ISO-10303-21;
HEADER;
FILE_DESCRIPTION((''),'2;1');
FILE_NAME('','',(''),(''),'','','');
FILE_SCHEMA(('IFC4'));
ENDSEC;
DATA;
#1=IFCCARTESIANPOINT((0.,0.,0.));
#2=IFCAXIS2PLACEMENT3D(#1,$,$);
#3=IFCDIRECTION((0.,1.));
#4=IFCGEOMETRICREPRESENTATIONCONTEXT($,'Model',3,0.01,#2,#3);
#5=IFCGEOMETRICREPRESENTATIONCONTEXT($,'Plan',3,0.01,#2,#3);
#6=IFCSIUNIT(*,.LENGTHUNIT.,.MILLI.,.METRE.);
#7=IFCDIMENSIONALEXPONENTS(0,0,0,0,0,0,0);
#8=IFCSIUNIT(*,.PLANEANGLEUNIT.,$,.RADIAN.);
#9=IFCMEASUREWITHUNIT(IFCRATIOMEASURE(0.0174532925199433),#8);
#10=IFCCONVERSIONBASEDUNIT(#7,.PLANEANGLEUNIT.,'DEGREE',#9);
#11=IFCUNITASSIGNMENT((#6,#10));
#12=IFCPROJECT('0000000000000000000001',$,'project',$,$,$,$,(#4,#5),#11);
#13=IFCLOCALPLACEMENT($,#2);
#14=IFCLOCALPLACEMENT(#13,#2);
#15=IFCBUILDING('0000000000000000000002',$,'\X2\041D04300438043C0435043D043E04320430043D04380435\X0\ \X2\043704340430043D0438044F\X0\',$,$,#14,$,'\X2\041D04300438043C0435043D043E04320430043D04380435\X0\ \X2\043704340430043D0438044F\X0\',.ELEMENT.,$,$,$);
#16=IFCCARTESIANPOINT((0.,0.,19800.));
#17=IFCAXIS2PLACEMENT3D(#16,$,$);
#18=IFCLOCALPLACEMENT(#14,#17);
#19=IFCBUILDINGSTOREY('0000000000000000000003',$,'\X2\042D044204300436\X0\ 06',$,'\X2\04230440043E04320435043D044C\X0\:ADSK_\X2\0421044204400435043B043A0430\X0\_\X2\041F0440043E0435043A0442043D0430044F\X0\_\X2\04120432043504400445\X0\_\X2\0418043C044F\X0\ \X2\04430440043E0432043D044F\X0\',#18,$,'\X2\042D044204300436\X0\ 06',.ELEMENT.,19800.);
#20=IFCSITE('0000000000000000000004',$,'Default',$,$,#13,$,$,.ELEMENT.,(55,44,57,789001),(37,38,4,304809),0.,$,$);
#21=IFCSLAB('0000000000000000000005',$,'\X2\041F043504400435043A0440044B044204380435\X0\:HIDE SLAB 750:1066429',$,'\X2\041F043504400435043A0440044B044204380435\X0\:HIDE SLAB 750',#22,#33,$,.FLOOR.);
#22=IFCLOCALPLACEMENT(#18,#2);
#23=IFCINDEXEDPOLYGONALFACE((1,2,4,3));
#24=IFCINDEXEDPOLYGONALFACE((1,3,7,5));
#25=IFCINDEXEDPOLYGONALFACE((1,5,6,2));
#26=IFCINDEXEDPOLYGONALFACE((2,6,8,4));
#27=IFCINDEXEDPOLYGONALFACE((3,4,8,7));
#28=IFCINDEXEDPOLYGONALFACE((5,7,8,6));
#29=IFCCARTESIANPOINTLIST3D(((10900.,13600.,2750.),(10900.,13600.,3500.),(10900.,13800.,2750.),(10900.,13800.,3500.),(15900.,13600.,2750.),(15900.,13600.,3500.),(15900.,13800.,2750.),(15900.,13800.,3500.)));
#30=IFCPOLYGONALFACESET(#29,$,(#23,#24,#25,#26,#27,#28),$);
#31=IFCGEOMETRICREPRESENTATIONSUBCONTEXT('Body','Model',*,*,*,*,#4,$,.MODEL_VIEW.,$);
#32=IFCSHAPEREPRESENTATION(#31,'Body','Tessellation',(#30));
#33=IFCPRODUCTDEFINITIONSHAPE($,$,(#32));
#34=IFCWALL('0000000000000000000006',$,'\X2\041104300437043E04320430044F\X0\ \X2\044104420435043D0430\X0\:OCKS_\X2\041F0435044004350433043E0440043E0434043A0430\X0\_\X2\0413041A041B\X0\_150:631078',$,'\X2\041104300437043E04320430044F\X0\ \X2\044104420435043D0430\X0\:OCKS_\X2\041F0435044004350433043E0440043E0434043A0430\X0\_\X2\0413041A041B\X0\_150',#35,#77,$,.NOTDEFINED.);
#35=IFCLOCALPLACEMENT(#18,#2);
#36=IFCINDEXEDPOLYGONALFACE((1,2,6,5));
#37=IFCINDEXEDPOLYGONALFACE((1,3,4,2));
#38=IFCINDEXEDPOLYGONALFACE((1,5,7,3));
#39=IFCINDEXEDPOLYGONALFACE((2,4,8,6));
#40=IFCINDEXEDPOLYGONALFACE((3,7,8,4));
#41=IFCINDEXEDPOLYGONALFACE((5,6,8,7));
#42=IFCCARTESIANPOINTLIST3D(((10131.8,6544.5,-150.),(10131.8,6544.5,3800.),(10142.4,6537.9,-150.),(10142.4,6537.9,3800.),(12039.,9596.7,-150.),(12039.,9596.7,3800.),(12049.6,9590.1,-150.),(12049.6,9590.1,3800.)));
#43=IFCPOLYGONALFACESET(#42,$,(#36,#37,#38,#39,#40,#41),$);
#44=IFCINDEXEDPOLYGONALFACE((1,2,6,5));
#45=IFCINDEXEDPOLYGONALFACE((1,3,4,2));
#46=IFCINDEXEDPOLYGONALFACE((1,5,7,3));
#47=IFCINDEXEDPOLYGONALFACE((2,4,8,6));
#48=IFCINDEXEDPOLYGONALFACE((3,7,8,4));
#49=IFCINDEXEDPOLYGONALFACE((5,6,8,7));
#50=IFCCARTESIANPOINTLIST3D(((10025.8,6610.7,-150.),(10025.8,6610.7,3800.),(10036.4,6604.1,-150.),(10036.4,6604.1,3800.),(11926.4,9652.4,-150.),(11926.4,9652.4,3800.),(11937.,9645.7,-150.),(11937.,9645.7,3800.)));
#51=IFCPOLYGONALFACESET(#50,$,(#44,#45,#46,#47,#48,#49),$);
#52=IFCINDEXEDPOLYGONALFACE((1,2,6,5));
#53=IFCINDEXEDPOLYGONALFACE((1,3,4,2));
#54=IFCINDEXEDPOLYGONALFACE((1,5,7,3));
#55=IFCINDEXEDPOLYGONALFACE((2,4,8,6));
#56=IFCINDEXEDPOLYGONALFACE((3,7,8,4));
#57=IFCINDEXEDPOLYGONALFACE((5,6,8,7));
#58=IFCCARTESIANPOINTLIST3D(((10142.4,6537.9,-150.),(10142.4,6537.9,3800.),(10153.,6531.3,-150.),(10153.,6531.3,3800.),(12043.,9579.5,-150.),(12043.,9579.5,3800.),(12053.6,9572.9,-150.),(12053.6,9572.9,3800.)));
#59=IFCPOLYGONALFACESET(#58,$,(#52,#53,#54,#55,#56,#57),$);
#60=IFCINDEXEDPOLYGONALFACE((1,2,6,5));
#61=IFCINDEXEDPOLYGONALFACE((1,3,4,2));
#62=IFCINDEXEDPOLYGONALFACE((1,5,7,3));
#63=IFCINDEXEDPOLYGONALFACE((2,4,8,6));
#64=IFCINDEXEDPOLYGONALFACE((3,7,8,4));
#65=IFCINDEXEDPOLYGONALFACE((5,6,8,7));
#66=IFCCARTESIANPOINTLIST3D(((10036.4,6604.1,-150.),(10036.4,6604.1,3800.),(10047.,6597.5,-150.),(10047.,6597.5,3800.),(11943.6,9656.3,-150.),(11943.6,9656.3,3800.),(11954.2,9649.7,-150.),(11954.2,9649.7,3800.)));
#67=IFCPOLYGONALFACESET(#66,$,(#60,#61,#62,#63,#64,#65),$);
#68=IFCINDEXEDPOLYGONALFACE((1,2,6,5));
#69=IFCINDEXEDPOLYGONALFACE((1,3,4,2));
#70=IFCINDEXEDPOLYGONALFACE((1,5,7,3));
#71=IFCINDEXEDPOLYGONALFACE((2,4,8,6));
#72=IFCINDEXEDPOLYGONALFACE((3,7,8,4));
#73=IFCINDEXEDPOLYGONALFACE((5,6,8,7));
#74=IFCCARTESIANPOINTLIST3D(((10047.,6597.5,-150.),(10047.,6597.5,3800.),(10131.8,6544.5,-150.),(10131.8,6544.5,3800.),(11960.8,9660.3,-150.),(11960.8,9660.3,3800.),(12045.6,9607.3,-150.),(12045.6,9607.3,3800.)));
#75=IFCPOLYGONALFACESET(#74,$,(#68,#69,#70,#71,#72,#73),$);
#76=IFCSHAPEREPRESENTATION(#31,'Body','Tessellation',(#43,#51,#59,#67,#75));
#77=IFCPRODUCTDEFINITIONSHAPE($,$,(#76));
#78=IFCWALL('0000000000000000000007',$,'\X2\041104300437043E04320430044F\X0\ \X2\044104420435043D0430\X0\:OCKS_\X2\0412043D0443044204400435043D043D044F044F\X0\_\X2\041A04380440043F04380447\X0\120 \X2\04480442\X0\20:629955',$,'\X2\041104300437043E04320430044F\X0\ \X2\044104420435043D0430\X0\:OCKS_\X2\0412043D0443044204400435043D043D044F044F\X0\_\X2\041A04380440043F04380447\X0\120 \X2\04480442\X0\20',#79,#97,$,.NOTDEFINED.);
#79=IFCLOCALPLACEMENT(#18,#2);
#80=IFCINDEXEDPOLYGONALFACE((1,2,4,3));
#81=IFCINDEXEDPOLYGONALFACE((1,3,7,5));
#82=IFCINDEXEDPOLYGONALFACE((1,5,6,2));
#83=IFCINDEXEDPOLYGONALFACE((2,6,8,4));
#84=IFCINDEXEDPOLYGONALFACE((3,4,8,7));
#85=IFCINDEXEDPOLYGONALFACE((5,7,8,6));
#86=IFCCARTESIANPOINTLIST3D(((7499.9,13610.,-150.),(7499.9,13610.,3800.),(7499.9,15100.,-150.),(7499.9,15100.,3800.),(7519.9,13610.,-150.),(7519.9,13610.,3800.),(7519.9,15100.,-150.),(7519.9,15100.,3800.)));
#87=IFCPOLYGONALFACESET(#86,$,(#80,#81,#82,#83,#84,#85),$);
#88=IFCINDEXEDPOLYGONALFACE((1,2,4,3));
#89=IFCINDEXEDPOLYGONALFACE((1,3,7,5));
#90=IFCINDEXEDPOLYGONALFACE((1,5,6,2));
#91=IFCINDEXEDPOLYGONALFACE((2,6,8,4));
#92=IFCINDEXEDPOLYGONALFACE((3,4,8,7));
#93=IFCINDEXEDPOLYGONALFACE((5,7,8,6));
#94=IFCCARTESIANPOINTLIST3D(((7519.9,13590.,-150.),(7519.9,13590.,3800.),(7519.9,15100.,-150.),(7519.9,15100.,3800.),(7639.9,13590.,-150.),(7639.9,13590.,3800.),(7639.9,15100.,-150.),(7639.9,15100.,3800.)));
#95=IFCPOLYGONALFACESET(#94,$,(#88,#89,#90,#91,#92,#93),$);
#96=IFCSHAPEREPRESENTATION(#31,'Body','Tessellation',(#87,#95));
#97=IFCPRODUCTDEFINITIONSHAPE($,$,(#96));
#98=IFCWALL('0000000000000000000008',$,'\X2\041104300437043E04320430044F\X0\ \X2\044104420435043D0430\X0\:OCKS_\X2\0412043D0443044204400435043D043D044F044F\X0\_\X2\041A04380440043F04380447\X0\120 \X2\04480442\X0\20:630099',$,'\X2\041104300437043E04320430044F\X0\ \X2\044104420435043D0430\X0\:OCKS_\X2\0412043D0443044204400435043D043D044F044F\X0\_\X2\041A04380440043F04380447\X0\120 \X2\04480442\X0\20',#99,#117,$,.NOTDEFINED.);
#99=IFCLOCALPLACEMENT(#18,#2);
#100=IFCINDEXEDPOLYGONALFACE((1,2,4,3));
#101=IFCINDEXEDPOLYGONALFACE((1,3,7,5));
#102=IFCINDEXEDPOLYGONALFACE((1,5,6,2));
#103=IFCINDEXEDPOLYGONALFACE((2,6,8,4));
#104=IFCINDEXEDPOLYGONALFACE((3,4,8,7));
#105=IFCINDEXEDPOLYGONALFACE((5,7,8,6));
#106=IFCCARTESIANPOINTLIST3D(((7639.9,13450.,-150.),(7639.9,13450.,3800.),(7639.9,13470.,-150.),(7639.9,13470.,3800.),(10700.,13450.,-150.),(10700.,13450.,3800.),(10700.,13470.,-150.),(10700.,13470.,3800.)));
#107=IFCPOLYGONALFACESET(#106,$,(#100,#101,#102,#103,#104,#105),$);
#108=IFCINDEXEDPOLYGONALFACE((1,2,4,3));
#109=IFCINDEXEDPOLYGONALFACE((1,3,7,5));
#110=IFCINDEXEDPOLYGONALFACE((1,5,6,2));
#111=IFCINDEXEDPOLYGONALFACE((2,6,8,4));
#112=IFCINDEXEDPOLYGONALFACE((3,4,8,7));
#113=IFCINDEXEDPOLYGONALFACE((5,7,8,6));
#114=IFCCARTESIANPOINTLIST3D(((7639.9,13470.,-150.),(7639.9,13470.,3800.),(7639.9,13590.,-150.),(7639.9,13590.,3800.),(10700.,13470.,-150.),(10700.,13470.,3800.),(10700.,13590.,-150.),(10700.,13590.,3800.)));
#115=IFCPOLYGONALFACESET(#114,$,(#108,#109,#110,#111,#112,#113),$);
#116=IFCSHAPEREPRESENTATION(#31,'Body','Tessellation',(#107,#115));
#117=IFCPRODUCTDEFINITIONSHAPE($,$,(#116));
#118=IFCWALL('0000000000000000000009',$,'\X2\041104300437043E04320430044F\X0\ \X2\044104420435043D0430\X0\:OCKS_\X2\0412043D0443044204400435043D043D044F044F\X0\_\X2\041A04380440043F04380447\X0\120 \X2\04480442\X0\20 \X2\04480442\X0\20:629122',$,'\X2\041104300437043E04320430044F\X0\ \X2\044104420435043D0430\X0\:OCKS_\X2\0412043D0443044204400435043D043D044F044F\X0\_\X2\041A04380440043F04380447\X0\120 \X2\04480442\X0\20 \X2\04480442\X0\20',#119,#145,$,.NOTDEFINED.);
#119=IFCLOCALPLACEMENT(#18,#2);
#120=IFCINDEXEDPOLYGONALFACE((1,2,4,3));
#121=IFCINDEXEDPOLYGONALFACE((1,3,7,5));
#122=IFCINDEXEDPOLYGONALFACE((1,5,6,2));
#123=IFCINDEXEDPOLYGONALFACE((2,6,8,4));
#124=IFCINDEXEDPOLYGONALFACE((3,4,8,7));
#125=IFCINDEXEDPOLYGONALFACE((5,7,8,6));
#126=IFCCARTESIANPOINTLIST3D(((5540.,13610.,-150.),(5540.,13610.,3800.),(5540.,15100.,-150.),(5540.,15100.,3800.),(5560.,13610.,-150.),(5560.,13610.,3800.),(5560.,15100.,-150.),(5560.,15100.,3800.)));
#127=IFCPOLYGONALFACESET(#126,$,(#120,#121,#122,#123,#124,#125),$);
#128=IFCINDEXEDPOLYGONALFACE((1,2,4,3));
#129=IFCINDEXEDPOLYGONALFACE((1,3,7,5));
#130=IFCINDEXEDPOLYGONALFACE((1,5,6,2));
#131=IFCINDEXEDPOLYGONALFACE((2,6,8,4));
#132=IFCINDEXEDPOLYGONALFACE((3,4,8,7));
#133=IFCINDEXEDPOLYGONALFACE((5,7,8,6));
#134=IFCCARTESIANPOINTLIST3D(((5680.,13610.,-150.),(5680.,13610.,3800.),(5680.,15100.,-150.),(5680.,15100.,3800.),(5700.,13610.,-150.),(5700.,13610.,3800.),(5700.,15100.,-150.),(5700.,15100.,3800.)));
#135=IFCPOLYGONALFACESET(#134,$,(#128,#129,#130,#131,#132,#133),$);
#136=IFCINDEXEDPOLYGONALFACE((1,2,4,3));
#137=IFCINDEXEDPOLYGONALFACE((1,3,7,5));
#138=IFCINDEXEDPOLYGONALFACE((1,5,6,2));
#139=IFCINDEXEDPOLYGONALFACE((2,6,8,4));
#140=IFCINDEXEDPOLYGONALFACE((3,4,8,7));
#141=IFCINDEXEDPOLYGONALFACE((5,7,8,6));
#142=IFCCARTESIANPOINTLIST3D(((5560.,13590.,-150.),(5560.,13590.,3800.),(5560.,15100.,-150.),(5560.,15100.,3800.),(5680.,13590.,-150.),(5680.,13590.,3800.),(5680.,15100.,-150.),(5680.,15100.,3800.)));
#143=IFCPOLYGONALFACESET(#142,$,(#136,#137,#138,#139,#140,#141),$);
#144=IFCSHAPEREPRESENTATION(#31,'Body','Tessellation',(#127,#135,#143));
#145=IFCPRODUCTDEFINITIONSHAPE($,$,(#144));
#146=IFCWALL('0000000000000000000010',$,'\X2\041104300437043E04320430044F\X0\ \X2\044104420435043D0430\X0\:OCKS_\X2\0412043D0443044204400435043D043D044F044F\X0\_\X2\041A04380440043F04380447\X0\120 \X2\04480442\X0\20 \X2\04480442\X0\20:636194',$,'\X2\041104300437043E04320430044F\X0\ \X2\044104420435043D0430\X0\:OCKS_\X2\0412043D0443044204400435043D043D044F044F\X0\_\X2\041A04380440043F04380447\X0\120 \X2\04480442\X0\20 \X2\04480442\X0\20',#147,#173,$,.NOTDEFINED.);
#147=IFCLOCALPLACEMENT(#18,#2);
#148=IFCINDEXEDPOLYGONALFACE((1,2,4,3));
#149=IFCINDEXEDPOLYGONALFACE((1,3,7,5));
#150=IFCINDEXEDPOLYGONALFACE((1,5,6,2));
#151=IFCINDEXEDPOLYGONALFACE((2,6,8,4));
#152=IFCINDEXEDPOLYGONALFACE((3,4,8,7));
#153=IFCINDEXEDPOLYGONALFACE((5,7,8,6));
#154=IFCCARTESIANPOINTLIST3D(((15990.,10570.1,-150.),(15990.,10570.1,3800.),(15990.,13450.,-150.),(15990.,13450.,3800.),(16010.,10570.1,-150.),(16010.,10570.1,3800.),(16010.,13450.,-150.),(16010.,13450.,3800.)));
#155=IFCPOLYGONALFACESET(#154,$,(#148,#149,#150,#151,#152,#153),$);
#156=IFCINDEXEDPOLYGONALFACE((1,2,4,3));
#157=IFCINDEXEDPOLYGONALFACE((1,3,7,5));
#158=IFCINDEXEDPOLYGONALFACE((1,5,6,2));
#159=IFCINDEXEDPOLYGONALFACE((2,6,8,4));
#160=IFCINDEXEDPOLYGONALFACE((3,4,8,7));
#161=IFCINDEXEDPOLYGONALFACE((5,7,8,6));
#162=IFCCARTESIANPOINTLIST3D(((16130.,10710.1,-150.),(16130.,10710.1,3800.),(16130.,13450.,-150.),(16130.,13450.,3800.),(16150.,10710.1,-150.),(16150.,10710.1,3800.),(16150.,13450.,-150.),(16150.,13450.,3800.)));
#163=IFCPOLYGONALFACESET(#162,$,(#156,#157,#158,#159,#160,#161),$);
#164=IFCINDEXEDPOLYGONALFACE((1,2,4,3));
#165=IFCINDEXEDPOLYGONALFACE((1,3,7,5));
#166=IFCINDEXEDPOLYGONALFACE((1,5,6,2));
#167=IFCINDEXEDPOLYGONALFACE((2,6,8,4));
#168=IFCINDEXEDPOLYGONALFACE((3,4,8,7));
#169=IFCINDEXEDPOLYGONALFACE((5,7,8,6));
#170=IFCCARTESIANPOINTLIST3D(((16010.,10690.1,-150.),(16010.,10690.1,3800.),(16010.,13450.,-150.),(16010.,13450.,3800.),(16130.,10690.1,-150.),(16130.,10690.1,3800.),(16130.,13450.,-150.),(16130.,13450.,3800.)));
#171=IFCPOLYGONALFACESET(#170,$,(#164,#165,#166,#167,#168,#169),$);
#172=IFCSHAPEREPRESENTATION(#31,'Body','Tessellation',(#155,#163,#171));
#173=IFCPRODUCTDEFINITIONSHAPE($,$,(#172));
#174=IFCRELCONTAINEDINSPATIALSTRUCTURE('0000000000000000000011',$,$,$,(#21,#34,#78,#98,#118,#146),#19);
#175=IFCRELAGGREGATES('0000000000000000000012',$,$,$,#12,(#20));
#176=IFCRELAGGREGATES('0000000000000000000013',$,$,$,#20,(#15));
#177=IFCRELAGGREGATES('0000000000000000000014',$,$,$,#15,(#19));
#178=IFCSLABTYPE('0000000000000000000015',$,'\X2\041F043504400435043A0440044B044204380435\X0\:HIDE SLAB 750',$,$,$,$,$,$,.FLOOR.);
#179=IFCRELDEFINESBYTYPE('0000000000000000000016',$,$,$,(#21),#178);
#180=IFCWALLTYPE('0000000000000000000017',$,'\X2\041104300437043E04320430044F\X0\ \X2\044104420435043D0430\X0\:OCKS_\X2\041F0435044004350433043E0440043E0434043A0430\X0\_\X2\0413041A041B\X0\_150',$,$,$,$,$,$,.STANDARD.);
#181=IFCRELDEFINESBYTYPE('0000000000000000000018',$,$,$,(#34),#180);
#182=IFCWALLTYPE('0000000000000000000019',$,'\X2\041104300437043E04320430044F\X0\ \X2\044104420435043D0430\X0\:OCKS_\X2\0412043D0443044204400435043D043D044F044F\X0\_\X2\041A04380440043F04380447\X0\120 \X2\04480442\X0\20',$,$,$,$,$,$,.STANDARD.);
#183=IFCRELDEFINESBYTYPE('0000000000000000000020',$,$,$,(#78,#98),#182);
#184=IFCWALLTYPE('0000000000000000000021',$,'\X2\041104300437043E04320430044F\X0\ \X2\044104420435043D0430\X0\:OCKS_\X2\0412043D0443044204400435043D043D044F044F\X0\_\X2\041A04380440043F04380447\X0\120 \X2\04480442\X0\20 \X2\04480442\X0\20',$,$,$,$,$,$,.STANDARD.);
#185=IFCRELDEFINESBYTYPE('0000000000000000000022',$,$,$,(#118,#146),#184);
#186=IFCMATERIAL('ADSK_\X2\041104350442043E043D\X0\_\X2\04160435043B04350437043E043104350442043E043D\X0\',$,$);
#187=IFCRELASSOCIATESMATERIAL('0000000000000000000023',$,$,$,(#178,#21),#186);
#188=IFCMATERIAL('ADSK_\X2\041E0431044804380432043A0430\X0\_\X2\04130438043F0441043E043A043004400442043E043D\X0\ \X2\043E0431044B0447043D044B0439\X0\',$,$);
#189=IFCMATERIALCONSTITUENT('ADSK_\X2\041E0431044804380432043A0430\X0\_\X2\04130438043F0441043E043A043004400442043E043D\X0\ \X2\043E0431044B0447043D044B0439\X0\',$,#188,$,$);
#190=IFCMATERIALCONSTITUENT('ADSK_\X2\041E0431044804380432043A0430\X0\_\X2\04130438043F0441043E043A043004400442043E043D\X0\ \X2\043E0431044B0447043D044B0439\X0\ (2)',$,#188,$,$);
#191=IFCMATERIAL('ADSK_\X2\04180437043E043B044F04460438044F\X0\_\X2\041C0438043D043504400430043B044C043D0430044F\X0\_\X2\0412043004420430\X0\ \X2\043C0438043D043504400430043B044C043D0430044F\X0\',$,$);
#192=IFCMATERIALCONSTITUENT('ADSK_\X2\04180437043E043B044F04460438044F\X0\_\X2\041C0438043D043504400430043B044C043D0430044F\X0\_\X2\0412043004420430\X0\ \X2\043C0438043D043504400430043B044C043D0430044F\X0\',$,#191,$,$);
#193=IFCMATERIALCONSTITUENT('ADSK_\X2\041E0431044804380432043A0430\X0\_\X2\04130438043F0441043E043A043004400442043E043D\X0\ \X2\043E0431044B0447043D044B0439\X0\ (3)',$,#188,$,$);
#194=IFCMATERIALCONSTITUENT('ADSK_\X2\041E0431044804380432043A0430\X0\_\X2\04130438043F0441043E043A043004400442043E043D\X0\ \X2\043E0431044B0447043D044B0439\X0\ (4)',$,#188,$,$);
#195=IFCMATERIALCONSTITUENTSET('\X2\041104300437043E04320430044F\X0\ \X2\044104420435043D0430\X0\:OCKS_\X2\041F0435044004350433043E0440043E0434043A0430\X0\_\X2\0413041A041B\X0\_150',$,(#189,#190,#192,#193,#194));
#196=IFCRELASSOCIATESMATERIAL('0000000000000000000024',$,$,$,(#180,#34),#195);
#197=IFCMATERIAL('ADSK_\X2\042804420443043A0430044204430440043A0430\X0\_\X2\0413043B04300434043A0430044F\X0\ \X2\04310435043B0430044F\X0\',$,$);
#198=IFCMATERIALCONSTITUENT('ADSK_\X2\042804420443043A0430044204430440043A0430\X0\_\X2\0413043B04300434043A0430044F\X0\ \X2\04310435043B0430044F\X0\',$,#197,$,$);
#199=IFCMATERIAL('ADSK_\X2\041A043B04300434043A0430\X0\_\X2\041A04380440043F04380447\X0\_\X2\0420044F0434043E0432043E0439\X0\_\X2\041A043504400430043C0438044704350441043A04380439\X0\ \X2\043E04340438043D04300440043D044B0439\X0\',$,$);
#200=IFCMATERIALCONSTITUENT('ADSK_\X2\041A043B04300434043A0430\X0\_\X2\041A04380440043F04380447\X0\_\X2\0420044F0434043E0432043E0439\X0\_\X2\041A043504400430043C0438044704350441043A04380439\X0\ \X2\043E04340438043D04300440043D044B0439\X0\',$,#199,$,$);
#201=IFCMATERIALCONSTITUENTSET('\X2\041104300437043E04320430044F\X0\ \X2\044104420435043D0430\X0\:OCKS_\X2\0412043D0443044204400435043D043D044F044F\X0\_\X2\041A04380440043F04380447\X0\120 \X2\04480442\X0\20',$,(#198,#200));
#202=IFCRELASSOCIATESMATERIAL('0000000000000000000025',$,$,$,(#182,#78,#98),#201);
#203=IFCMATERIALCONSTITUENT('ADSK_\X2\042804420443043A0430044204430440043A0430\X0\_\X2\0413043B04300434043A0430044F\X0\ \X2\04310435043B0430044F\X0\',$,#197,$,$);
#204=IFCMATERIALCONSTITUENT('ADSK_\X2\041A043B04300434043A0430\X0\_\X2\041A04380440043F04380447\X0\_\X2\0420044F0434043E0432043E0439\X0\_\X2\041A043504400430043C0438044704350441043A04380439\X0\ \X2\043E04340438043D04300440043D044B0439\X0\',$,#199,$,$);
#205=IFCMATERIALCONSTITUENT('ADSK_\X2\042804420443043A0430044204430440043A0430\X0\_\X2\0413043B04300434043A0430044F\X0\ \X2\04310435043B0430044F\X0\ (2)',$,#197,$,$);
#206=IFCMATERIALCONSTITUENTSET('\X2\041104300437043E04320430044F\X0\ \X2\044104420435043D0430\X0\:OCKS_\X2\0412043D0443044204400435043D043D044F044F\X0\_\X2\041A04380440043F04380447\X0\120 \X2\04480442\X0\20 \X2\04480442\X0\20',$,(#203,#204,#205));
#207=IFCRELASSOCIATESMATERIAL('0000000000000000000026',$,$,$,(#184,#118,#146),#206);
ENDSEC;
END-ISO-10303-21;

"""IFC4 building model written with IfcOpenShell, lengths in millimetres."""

from ifc_helpers import new_model, entity, si_unit, converted_unit, direction, frame, origin, place, context, subcontext, project, spatial, indexed_curve, outline, extrude, material, constituent, constituent_set, type_object, element, save


model = new_model("IFC4")

# Units and contexts
model_context = context("Model", 3, precision=0.01, world=origin(), true_north=direction((0.0, 1.0)))
plan_context = context("Plan", 3, precision=0.01, world=origin(), true_north=direction((0.0, 1.0)))
body_context = subcontext(model_context, "Body", "Model", "MODEL_VIEW")
ifc_project = project(units=[si_unit("LENGTHUNIT", "METRE", prefix="MILLI"), converted_unit("PLANEANGLEUNIT", "DEGREE", entity("IfcRatioMeasure", 0.0174532925199433), si_unit("PLANEANGLEUNIT", "RADIAN"), dimensions=[0, 0, 0, 0, 0, 0, 0])], contexts=[model_context, plan_context])

# Site, building, storey
site_placement = place(None, frame((0.0, 0.0, 0.0)))
site = spatial("IfcSite", under=ifc_project, at=site_placement, Name="Default", CompositionType="ELEMENT", RefLatitude=(55, 44, 57, 789001), RefLongitude=(37, 38, 4, 304809), RefElevation=0.0)
building_placement = place(site_placement, origin())
building = spatial("IfcBuilding", under=site, at=building_placement, Name="Наименование здания", LongName="Наименование здания", CompositionType="ELEMENT")
storey_placement = place(building_placement, frame((0.0, 0.0, 19800.0)))
storey = spatial("IfcBuildingStorey", under=building, at=storey_placement, Name="Этаж 06", ObjectType="Уровень:ADSK_Стрелка_Проектная_Вверх_Имя уровня", LongName="Этаж 06", CompositionType="ELEMENT", Elevation=19800.0)

# Slab
ifc_material_1 = material(Name="ADSK_Бетон_Железобетон")
slab_type_1 = type_object("IfcSlabType", Name="Перекрытие:HIDE SLAB 750", PredefinedType="FLOOR", material=ifc_material_1)
slab_1_placement = place(storey_placement, origin())
element("IfcSlab", 1, at=slab_1_placement, inside=storey, type_object=slab_type_1, material=ifc_material_1, Name="Перекрытие:HIDE SLAB 750:1066429", ObjectType="Перекрытие:HIDE SLAB 750", PredefinedType="FLOOR", context=body_context, shape_type="SweptSolid", body=[
    extrude(outline(indexed_curve([(-100.0, -2500.0), (100.0, -2500.0), (100.0, 2500.0), (-100.0, 2500.0), (-100.0, -2500.0)], self_intersect=False)), frame((13400.0, 13700.0, 3500.0), z_axis=(0.0, 0.0, -1.0), x_axis=(0.0, 1.0, 0.0)), (0.0, 0.0, 1.0), 750.0),
])

# Shared definitions
ifc_material_2 = material(Name="ADSK_Обшивка_Гипсокартон обычный")
ifc_constituent_1 = constituent(ifc_material_2, Name="ADSK_Обшивка_Гипсокартон обычный")
ifc_constituent_2 = constituent(ifc_material_2, Name="ADSK_Обшивка_Гипсокартон обычный (2)")
ifc_material_3 = material(Name="ADSK_Изоляция_Минеральная_Вата минеральная")
ifc_constituent_3 = constituent(ifc_material_3, Name="ADSK_Изоляция_Минеральная_Вата минеральная")
ifc_constituent_4 = constituent(ifc_material_2, Name="ADSK_Обшивка_Гипсокартон обычный (3)")
ifc_constituent_5 = constituent(ifc_material_2, Name="ADSK_Обшивка_Гипсокартон обычный (4)")
ifc_constituent_set_1 = constituent_set(constituents=[ifc_constituent_1, ifc_constituent_2, ifc_constituent_3, ifc_constituent_4, ifc_constituent_5], Name="Базовая стена:OCKS_Перегородка_ГКЛ_150")
wall_type_1 = type_object("IfcWallType", Name="Базовая стена:OCKS_Перегородка_ГКЛ_150", PredefinedType="STANDARD", material=ifc_constituent_set_1)

# Walls
wall_1_placement = place(storey_placement, frame((11990.0, 9612.6, -150.0), z_axis=(0.0, 0.0, 1.0), x_axis=(-0.529919, -0.848048, 0.0)))
element("IfcWall", 2, at=wall_1_placement, inside=storey, type_object=wall_type_1, material=ifc_constituent_set_1, Name="Базовая стена:OCKS_Перегородка_ГКЛ_150:631078", ObjectType="Базовая стена:OCKS_Перегородка_ГКЛ_150", PredefinedType="NOTDEFINED", context=body_context, shape_type="SweptSolid", body=[
    extrude(outline(indexed_curve([(-1799.6, -6.3), (1799.6, -6.3), (1799.6, 6.2), (-1799.6, 6.3), (-1799.6, -6.3)], self_intersect=False)), frame((1787.1, 56.2, 0.0)), (0.0, 0.0, 1.0), 3950.0),
    extrude(outline(indexed_curve([(-6.3, -1793.3), (6.2, -1793.3), (6.3, 1793.3), (-6.2, 1793.3), (-6.3, -1793.3)], self_intersect=False)), frame((1793.3, -68.7, 0.0), z_axis=(0.0, 0.0, 1.0), x_axis=(0.0, 1.0, 0.0)), (0.0, 0.0, 1.0), 3950.0),
    extrude(outline(indexed_curve([(-6.2, -1793.3), (6.3, -1793.3), (6.2, 1793.3), (-6.3, 1793.3), (-6.2, -1793.3)], self_intersect=False)), frame((1793.3, 68.7, 0.0), z_axis=(0.0, 0.0, 1.0), x_axis=(0.0, -1.0, 0.0)), (0.0, 0.0, 1.0), 3950.0),
    extrude(outline(indexed_curve([(-1799.6, -6.2), (1799.6, -6.2), (1799.6, 6.3), (-1799.6, 6.2), (-1799.6, -6.2)], self_intersect=False)), frame((1787.1, -56.3, 0.0)), (0.0, 0.0, 1.0), 3950.0),
    extrude(outline(indexed_curve([(-1805.8, -50.0), (1805.8, -50.0), (1805.8, 50.0), (-1805.8, 50.0), (-1805.8, -50.0)], self_intersect=False)), frame((1780.8, 0.0, 0.0)), (0.0, 0.0, 1.0), 3950.0),
])
ifc_material_4 = material(Name="ADSK_Штукатурка_Гладкая белая")
ifc_constituent_6 = constituent(ifc_material_4, Name="ADSK_Штукатурка_Гладкая белая")
ifc_material_5 = material(Name="ADSK_Кладка_Кирпич_Рядовой_Керамический одинарный")
ifc_constituent_7 = constituent(ifc_material_5, Name="ADSK_Кладка_Кирпич_Рядовой_Керамический одинарный")
ifc_constituent_set_2 = constituent_set(constituents=[ifc_constituent_6, ifc_constituent_7], Name="Базовая стена:OCKS_Внутренняя_Кирпич120 шт20")
wall_type_2 = type_object("IfcWallType", Name="Базовая стена:OCKS_Внутренняя_Кирпич120 шт20", PredefinedType="STANDARD", material=ifc_constituent_set_2)
wall_2_placement = place(storey_placement, frame((7569.9, 15100.0, -150.0), z_axis=(0.0, 0.0, 1.0), x_axis=(0.0, -1.0, 0.0)))
element("IfcWall", 3, at=wall_2_placement, inside=storey, type_object=wall_type_2, material=ifc_constituent_set_2, Name="Базовая стена:OCKS_Внутренняя_Кирпич120 шт20:629955", ObjectType="Базовая стена:OCKS_Внутренняя_Кирпич120 шт20", PredefinedType="NOTDEFINED", context=body_context, shape_type="SweptSolid", body=[
    extrude(outline(indexed_curve([(-10.0, -745.0), (10.0, -745.0), (10.0, 745.0), (-10.0, 745.0), (-10.0, -745.0)], self_intersect=False)), frame((745.0, -60.0, 0.0), z_axis=(0.0, 0.0, 1.0), x_axis=(0.0, 1.0, 0.0)), (0.0, 0.0, 1.0), 3950.0),
    extrude(outline(indexed_curve([(-60.0, -755.0), (60.0, -755.0), (60.0, 755.0), (-60.0, 755.0), (-60.0, -755.0)], self_intersect=False)), frame((755.0, 10.0, 0.0), z_axis=(0.0, 0.0, 1.0), x_axis=(0.0, -1.0, 0.0)), (0.0, 0.0, 1.0), 3950.0),
])
wall_3_placement = place(storey_placement, frame((10700.0, 13520.0, -150.0), z_axis=(0.0, 0.0, 1.0), x_axis=(-1.0, 0.0, 0.0)))
element("IfcWall", 4, at=wall_3_placement, inside=storey, type_object=wall_type_2, material=ifc_constituent_set_2, Name="Базовая стена:OCKS_Внутренняя_Кирпич120 шт20:630099", ObjectType="Базовая стена:OCKS_Внутренняя_Кирпич120 шт20", PredefinedType="NOTDEFINED", context=body_context, shape_type="SweptSolid", body=[
    extrude(outline(indexed_curve([(-10.0, -1530.1), (10.0, -1530.1), (10.0, 1530.1), (-10.0, 1530.1), (-10.0, -1530.1)], self_intersect=False)), frame((1530.1, 60.0, 0.0), z_axis=(0.0, 0.0, 1.0), x_axis=(0.0, -1.0, 0.0)), (0.0, 0.0, 1.0), 3950.0),
    extrude(outline(indexed_curve([(-60.0, -1530.1), (60.0, -1530.1), (60.0, 1530.1), (-60.0, 1530.1), (-60.0, -1530.1)], self_intersect=False)), frame((1530.1, -10.0, 0.0), z_axis=(0.0, 0.0, 1.0), x_axis=(0.0, 1.0, 0.0)), (0.0, 0.0, 1.0), 3950.0),
])

# Shared definitions
ifc_constituent_8 = constituent(ifc_material_4, Name="ADSK_Штукатурка_Гладкая белая")
ifc_constituent_9 = constituent(ifc_material_5, Name="ADSK_Кладка_Кирпич_Рядовой_Керамический одинарный")
ifc_constituent_10 = constituent(ifc_material_4, Name="ADSK_Штукатурка_Гладкая белая (2)")
ifc_constituent_set_3 = constituent_set(constituents=[ifc_constituent_8, ifc_constituent_9, ifc_constituent_10], Name="Базовая стена:OCKS_Внутренняя_Кирпич120 шт20 шт20")
wall_type_3 = type_object("IfcWallType", Name="Базовая стена:OCKS_Внутренняя_Кирпич120 шт20 шт20", PredefinedType="STANDARD", material=ifc_constituent_set_3)

# Wall
wall_4_placement = place(storey_placement, frame((5620.0, 15100.0, -150.0), z_axis=(0.0, 0.0, 1.0), x_axis=(0.0, -1.0, 0.0)))
element("IfcWall", 5, at=wall_4_placement, inside=storey, type_object=wall_type_3, material=ifc_constituent_set_3, Name="Базовая стена:OCKS_Внутренняя_Кирпич120 шт20 шт20:629122", ObjectType="Базовая стена:OCKS_Внутренняя_Кирпич120 шт20 шт20", PredefinedType="NOTDEFINED", context=body_context, shape_type="SweptSolid", body=[
    extrude(outline(indexed_curve([(-10.0, -745.0), (10.0, -745.0), (10.0, 745.0), (-10.0, 745.0), (-10.0, -745.0)], self_intersect=False)), frame((745.0, -70.0, 0.0), z_axis=(0.0, 0.0, 1.0), x_axis=(0.0, 1.0, 0.0)), (0.0, 0.0, 1.0), 3950.0),
    extrude(outline(indexed_curve([(-10.0, -745.0), (10.0, -745.0), (10.0, 745.0), (-10.0, 745.0), (-10.0, -745.0)], self_intersect=False)), frame((745.0, 70.0, 0.0), z_axis=(0.0, 0.0, 1.0), x_axis=(0.0, -1.0, 0.0)), (0.0, 0.0, 1.0), 3950.0),
    extrude(outline(indexed_curve([(-755.0, -60.0), (755.0, -60.0), (755.0, 60.0), (-755.0, 60.0), (-755.0, -60.0)], self_intersect=False)), frame((755.0, 0.0, 0.0)), (0.0, 0.0, 1.0), 3950.0),
])

# Wall
wall_5_placement = place(storey_placement, frame((16070.0, 13450.0, -150.0), z_axis=(0.0, 0.0, 1.0), x_axis=(0.0, -1.0, 0.0)))
element("IfcWall", 6, at=wall_5_placement, inside=storey, type_object=wall_type_3, material=ifc_constituent_set_3, Name="Базовая стена:OCKS_Внутренняя_Кирпич120 шт20 шт20:636194", ObjectType="Базовая стена:OCKS_Внутренняя_Кирпич120 шт20 шт20", PredefinedType="NOTDEFINED", context=body_context, shape_type="SweptSolid", body=[
    extrude(outline(indexed_curve([(-10.0, -1439.9), (10.0, -1439.9), (10.0, 1439.9), (-10.0, 1439.9), (-10.0, -1439.9)], self_intersect=False)), frame((1439.9, -70.0, 0.0), z_axis=(0.0, 0.0, 1.0), x_axis=(0.0, 1.0, 0.0)), (0.0, 0.0, 1.0), 3950.0),
    extrude(outline(indexed_curve([(-10.0, -1369.9), (10.0, -1369.9), (10.0, 1369.9), (-10.0, 1369.9), (-10.0, -1369.9)], self_intersect=False)), frame((1369.9, 70.0, 0.0), z_axis=(0.0, 0.0, 1.0), x_axis=(0.0, -1.0, 0.0)), (0.0, 0.0, 1.0), 3950.0),
    extrude(outline(indexed_curve([(-1379.9, -60.0), (1379.9, -60.0), (1379.9, 60.0), (-1379.9, 60.0), (-1379.9, -60.0)], self_intersect=False)), frame((1379.9, 0.0, 0.0)), (0.0, 0.0, 1.0), 3950.0),
])

save(model, "model.ifc")
